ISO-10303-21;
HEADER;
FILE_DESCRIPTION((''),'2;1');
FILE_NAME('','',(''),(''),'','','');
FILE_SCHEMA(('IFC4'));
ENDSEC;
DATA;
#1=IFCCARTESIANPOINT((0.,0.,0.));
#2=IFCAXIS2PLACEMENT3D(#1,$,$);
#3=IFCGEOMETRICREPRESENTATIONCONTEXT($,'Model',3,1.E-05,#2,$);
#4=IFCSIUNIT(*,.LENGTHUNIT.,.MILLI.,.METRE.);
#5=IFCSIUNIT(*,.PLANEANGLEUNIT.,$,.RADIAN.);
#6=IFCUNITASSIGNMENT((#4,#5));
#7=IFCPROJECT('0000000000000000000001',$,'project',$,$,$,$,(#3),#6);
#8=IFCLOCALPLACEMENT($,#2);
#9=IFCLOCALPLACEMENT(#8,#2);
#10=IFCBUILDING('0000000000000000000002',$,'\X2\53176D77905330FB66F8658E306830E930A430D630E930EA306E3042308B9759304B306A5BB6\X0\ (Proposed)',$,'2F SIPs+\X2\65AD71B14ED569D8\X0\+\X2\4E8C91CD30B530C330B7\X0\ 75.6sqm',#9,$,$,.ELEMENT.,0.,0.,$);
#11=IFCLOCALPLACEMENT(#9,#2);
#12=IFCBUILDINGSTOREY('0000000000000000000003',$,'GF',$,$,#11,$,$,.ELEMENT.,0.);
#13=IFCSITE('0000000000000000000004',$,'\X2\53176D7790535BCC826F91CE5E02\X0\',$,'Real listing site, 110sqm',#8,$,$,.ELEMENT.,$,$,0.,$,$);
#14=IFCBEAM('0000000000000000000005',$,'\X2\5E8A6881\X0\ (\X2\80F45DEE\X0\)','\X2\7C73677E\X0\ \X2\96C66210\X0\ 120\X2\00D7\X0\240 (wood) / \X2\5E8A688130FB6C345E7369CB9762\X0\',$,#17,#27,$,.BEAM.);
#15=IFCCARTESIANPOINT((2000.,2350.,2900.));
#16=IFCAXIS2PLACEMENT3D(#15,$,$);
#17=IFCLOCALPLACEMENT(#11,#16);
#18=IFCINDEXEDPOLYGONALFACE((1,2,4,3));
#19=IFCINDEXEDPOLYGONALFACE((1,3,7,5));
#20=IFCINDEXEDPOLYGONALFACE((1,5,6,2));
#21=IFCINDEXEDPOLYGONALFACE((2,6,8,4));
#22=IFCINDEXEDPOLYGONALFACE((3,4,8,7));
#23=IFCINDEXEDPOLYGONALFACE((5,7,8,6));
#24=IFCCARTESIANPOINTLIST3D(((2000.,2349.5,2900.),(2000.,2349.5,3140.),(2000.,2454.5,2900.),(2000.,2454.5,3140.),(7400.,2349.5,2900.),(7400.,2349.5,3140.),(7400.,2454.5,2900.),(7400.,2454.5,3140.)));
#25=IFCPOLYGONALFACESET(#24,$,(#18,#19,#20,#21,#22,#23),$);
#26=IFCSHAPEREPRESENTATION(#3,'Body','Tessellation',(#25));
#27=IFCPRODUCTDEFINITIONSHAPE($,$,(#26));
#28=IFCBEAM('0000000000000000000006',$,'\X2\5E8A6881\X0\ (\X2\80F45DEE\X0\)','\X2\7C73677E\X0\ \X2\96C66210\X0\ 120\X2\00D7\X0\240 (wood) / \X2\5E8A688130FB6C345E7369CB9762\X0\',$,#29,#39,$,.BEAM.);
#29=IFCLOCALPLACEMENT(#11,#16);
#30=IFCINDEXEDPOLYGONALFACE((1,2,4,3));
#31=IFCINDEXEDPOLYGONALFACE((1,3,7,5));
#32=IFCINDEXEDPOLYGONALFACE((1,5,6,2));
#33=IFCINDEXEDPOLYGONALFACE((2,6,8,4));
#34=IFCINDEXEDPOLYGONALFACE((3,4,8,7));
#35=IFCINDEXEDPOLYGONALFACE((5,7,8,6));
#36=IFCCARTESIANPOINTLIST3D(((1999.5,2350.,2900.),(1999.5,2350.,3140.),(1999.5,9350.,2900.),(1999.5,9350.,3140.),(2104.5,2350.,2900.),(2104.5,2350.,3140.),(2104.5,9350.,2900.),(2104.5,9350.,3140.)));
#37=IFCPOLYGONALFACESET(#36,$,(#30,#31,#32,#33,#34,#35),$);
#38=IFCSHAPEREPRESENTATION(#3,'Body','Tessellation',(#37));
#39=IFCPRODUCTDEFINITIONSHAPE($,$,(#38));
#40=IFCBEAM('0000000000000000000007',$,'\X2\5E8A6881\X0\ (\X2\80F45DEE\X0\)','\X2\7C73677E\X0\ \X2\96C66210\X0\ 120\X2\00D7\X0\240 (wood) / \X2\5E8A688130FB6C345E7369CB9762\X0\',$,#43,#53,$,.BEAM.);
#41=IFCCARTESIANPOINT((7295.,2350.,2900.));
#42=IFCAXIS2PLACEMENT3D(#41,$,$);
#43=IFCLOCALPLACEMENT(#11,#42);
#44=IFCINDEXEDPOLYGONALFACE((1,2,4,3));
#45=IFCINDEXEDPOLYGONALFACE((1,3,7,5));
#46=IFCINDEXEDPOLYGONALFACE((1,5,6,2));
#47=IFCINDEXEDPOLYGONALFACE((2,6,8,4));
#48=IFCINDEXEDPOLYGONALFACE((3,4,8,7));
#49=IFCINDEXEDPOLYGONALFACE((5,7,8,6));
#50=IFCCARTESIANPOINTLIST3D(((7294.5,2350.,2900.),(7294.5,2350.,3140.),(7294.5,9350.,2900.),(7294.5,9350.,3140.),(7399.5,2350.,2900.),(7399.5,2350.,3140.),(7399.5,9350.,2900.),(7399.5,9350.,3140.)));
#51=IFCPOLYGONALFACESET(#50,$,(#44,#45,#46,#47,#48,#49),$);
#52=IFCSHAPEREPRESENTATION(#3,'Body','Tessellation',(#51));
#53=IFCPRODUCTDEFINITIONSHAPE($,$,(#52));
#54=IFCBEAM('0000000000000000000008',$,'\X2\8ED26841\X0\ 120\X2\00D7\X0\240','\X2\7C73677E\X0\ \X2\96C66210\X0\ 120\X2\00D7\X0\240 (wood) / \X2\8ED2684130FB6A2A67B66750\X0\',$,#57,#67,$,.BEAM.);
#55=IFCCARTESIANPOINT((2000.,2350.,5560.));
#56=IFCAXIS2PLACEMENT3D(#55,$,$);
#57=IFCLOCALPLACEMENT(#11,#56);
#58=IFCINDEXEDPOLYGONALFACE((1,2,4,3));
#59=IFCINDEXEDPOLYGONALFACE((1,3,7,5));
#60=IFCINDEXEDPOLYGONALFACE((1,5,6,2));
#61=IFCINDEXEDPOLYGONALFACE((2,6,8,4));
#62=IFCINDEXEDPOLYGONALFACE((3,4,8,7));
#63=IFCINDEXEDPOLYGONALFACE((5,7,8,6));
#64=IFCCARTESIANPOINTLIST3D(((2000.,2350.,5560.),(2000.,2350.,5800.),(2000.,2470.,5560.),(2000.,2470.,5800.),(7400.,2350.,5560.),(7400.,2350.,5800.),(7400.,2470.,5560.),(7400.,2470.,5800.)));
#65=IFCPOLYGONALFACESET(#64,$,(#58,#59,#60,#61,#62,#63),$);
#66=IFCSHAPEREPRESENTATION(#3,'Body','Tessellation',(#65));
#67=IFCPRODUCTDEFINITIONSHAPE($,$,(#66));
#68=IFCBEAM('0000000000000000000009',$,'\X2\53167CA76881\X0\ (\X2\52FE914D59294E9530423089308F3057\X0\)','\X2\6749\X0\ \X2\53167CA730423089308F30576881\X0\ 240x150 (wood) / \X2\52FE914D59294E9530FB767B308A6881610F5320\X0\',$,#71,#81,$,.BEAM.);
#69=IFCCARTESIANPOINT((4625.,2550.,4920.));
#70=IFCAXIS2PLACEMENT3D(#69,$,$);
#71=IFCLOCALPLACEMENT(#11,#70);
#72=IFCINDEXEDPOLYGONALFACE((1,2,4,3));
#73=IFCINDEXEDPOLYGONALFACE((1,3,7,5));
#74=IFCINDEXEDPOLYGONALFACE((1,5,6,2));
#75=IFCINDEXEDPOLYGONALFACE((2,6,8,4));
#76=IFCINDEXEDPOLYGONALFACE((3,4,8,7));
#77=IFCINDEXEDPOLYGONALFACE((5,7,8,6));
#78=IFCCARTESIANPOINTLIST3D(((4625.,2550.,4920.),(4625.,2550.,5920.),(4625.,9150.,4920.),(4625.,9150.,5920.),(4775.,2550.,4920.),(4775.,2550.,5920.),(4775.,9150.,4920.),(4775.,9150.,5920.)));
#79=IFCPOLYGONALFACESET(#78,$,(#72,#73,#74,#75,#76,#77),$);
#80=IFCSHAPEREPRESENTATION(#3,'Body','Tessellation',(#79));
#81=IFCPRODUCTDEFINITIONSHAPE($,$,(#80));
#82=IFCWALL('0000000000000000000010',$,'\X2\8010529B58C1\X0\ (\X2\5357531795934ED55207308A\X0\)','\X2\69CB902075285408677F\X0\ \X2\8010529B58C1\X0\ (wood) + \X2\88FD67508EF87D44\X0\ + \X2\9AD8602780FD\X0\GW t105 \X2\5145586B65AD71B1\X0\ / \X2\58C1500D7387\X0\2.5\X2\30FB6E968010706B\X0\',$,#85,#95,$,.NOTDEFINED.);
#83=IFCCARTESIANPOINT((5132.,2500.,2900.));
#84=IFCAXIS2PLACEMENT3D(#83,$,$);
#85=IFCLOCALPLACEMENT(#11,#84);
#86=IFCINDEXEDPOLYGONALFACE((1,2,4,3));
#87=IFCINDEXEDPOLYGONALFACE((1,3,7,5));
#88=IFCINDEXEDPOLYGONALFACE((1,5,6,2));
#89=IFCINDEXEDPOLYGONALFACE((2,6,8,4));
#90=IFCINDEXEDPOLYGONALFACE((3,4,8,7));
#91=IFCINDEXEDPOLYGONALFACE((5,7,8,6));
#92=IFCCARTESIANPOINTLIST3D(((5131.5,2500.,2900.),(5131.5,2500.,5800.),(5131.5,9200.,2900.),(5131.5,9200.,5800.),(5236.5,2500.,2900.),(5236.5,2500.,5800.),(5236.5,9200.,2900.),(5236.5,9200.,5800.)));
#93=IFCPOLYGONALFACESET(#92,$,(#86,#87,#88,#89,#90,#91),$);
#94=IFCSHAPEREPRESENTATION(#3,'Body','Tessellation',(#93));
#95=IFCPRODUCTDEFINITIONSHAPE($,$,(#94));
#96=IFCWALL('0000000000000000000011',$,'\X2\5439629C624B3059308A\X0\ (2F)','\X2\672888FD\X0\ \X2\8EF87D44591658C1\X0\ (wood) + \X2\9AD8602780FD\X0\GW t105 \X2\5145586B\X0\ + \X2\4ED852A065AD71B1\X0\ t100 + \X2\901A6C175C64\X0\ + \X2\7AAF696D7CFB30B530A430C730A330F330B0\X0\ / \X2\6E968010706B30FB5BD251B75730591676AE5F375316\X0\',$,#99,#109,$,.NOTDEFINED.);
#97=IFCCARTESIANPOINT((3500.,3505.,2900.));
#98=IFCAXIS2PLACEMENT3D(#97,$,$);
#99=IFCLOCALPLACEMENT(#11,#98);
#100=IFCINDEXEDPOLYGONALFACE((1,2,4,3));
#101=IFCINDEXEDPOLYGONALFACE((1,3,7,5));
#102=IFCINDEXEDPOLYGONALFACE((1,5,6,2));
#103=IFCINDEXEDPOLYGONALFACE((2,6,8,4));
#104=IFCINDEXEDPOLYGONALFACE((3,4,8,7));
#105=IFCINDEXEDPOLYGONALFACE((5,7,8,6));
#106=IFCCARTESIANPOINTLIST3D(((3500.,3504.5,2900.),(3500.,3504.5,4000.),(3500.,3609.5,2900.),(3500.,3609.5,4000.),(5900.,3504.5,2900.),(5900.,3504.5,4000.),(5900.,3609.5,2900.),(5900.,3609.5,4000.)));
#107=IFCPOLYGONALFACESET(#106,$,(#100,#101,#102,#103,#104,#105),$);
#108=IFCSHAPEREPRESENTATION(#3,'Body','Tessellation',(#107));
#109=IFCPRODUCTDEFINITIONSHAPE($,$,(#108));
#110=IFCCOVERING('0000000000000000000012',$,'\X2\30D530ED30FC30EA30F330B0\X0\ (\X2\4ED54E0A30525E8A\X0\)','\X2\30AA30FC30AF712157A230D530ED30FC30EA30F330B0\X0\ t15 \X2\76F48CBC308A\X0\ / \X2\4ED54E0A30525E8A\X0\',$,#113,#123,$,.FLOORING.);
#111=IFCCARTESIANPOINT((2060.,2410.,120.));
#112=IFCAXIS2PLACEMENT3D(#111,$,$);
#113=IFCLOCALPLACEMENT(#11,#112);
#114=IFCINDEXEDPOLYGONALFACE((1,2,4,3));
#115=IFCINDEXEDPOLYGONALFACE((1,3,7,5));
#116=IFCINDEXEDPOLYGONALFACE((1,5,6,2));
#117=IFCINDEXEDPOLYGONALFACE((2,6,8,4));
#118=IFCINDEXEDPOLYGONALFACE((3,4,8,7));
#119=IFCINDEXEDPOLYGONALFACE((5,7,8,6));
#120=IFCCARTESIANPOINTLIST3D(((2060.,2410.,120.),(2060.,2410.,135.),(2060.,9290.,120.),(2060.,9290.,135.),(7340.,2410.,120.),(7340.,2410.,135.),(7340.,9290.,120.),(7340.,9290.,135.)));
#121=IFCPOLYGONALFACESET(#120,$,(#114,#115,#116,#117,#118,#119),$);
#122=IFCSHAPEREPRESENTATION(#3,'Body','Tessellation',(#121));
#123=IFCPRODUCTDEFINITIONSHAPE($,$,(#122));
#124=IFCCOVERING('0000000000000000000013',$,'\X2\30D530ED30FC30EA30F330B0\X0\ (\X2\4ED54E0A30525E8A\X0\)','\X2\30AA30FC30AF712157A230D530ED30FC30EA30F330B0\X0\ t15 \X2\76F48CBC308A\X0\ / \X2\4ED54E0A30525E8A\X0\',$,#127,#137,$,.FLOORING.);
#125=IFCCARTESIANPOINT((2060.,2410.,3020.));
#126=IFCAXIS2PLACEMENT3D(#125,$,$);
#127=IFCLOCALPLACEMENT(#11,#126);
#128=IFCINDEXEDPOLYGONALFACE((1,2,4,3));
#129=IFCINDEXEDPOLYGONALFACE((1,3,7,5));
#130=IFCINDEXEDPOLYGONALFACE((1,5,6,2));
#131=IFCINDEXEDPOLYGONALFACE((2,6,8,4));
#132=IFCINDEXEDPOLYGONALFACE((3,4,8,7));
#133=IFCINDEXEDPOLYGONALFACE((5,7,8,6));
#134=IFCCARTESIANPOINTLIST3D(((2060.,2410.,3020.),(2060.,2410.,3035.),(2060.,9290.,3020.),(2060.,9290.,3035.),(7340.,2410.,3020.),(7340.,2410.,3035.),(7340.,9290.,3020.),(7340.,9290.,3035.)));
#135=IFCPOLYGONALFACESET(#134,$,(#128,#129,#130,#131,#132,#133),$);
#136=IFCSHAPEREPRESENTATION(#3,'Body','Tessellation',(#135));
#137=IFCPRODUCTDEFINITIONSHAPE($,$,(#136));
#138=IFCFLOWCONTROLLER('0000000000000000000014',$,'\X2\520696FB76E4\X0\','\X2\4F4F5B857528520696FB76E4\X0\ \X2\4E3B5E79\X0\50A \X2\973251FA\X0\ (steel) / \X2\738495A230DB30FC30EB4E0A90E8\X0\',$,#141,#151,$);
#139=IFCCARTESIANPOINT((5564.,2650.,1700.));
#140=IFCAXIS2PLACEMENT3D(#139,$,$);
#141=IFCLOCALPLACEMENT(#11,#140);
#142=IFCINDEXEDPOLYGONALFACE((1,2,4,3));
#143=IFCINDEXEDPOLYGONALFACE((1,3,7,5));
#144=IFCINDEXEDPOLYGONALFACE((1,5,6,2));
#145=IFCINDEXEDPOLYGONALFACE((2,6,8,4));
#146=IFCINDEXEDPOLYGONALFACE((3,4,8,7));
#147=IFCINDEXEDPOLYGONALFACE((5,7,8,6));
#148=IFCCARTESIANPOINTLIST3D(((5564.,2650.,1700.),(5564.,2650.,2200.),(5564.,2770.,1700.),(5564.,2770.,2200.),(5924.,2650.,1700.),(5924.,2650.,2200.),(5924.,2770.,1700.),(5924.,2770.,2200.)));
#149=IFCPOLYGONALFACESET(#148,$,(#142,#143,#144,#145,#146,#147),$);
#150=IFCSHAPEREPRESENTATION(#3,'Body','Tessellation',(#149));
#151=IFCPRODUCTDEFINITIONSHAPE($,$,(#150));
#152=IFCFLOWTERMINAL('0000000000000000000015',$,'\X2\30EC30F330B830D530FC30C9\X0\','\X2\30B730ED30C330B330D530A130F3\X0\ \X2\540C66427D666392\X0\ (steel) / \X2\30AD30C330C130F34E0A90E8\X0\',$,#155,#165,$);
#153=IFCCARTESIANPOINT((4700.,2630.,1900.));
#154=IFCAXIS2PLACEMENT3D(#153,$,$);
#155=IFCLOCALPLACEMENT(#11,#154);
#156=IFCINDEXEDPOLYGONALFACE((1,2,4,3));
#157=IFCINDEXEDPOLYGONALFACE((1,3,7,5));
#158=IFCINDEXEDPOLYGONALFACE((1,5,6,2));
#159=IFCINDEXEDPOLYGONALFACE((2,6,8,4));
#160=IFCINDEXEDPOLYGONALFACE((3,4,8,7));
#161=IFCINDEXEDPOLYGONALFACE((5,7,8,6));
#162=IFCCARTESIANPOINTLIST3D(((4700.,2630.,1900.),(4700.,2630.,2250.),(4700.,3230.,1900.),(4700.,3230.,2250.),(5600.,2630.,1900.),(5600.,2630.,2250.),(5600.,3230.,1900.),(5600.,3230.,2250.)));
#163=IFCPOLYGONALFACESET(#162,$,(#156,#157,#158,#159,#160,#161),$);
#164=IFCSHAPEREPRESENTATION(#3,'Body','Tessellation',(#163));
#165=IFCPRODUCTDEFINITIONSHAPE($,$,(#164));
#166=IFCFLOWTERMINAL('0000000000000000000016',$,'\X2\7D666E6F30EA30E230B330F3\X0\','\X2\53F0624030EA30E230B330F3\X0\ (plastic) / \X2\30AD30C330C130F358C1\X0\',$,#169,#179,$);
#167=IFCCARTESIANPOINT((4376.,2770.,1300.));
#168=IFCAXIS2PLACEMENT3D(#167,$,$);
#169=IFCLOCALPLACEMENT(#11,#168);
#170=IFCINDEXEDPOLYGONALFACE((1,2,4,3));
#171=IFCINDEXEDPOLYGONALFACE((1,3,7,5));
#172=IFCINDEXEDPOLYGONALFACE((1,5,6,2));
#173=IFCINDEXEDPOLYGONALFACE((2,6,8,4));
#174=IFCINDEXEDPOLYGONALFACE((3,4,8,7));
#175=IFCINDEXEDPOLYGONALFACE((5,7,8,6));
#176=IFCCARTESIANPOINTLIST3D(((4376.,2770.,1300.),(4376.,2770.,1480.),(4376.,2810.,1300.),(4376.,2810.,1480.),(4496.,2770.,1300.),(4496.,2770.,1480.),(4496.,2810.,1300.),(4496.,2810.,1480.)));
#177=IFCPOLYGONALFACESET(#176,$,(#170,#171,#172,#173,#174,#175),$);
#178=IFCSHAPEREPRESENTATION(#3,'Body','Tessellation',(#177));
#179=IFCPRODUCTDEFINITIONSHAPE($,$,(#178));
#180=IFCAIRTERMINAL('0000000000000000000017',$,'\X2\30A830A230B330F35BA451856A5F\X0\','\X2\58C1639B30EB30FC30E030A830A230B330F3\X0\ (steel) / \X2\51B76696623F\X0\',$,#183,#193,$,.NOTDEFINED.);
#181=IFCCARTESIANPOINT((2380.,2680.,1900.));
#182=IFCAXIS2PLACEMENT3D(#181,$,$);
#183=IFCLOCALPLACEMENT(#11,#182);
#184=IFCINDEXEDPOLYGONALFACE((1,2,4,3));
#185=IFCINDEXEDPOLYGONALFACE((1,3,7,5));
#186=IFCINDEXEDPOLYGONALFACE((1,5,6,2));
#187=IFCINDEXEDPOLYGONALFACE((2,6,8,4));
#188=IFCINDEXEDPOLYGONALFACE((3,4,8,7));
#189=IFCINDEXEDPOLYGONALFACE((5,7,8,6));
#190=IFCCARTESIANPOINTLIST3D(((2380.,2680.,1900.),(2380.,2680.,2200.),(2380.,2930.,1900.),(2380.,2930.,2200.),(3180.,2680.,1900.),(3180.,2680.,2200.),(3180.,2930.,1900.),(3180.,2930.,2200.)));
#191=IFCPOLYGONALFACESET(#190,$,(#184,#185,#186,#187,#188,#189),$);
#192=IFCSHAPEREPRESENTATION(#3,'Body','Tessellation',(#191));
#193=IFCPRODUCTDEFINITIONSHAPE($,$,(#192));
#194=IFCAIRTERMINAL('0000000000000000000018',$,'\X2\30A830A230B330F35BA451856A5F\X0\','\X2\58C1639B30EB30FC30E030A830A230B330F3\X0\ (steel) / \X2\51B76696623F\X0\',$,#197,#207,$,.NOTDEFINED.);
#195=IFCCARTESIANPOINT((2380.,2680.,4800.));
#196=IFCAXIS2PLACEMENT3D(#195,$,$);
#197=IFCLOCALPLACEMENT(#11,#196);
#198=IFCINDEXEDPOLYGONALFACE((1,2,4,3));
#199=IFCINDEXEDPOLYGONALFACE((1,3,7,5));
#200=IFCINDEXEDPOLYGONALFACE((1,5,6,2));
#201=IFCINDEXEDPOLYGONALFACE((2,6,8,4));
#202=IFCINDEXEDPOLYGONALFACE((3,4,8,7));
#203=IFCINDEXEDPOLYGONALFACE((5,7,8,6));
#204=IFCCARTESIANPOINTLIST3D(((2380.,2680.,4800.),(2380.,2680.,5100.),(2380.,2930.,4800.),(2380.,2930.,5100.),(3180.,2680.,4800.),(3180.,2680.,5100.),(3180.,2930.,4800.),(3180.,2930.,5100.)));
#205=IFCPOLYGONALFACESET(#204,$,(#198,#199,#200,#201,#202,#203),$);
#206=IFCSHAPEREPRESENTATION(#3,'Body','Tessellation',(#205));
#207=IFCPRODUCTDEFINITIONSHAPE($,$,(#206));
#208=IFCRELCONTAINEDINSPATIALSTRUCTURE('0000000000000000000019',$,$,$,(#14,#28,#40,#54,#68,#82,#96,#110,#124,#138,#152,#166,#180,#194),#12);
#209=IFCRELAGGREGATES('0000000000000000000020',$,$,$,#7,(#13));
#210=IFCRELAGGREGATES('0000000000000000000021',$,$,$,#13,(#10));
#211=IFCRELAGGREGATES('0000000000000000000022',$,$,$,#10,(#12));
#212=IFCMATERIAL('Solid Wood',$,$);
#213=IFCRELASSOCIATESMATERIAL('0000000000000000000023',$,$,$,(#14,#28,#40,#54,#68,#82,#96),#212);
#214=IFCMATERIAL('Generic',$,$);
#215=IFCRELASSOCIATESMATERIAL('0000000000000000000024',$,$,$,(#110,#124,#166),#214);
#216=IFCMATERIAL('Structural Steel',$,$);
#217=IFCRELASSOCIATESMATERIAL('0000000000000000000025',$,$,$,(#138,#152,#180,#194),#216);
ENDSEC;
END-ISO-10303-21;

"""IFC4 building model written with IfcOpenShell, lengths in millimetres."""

from ifc_helpers import new_model, si_unit, frame, frame_2d, origin, place, context, project, spatial, rectangle, extrude, material, element, save


model = new_model("IFC4")

# Units and contexts
model_context = context("Model", 3, precision=1e-05, world=origin())
ifc_project = project(units=[si_unit("LENGTHUNIT", "METRE", prefix="MILLI"), si_unit("PLANEANGLEUNIT", "RADIAN")], contexts=[model_context])

# Site, building, storey
site_placement = place(None, origin())
site = spatial("IfcSite", under=ifc_project, at=site_placement, Name="北海道富良野市", ObjectType="Real listing site, 110sqm", CompositionType="ELEMENT", RefElevation=0.0)
building_placement = place(site_placement, origin())
building = spatial("IfcBuilding", under=site, at=building_placement, Name="北海道・書斎とライブラリのある静かな家 (Proposed)", ObjectType="2F SIPs+断熱仕様+二重サッシ 75.6sqm", CompositionType="ELEMENT", ElevationOfRefHeight=0.0, ElevationOfTerrain=0.0)
storey_placement = place(building_placement, origin())
storey = spatial("IfcBuildingStorey", under=building, at=storey_placement, Name="GF", CompositionType="ELEMENT", Elevation=0.0)

# Beams
ifc_material_1 = material(Name="Solid Wood")
beam_1_placement = place(storey_placement, frame((2000.0, 2350.0, 2900.0)))
element("IfcBeam", 1, at=beam_1_placement, inside=storey, material=ifc_material_1, Name="床梁 (胴差)", Description="米松 集成 120×240 (wood) / 床梁・水平構面", PredefinedType="BEAM", context=model_context, shape_type="SweptSolid", body=[
    extrude(rectangle(XDim=5400.0, YDim=105.0, at=frame_2d((2700.0, 52.0))), frame((2000.0, 2350.0, 2900.0)), (0.0, 0.0, 1.0), 240.0),
])
beam_2_placement = place(storey_placement, frame((2000.0, 2350.0, 2900.0)))
element("IfcBeam", 2, at=beam_2_placement, inside=storey, material=ifc_material_1, Name="床梁 (胴差)", Description="米松 集成 120×240 (wood) / 床梁・水平構面", PredefinedType="BEAM", context=model_context, shape_type="SweptSolid", body=[
    extrude(rectangle(XDim=105.0, YDim=7000.0, at=frame_2d((52.0, 3500.0))), frame((2000.0, 2350.0, 2900.0)), (0.0, 0.0, 1.0), 240.0),
])
beam_3_placement = place(storey_placement, frame((7295.0, 2350.0, 2900.0)))
element("IfcBeam", 3, at=beam_3_placement, inside=storey, material=ifc_material_1, Name="床梁 (胴差)", Description="米松 集成 120×240 (wood) / 床梁・水平構面", PredefinedType="BEAM", context=model_context, shape_type="SweptSolid", body=[
    extrude(rectangle(XDim=105.0, YDim=7000.0, at=frame_2d((52.0, 3500.0))), frame((7295.0, 2350.0, 2900.0)), (0.0, 0.0, 1.0), 240.0),
])
beam_4_placement = place(storey_placement, frame((2000.0, 2350.0, 5560.0)))
element("IfcBeam", 4, at=beam_4_placement, inside=storey, material=ifc_material_1, Name="軒桁 120×240", Description="米松 集成 120×240 (wood) / 軒桁・横架材", PredefinedType="BEAM", context=model_context, shape_type="SweptSolid", body=[
    extrude(rectangle(XDim=5400.0, YDim=120.0, at=frame_2d((2700.0, 60.0))), frame((2000.0, 2350.0, 5560.0)), (0.0, 0.0, 1.0), 240.0),
])
beam_5_placement = place(storey_placement, frame((4625.0, 2550.0, 4920.0)))
element("IfcBeam", 5, at=beam_5_placement, inside=storey, material=ifc_material_1, Name="化粧梁 (勾配天井あらわし)", Description="杉 化粧あらわし梁 240x150 (wood) / 勾配天井・登り梁意匠", PredefinedType="BEAM", context=model_context, shape_type="SweptSolid", body=[
    extrude(rectangle(XDim=150.0, YDim=6600.0, at=frame_2d((75.0, 3300.0))), frame((4625.0, 2550.0, 4920.0)), (0.0, 0.0, 1.0), 1000.0),
])

# Walls
wall_1_placement = place(storey_placement, frame((5132.0, 2500.0, 2900.0)))
element("IfcWall", 6, at=wall_1_placement, inside=storey, material=ifc_material_1, Name="耐力壁 (南北間仕切り)", Description="構造用合板 耐力壁 (wood) + 製材軸組 + 高性能GW t105 充填断熱 / 壁倍率2.5・準耐火", PredefinedType="NOTDEFINED", context=model_context, shape_type="SweptSolid", body=[
    extrude(rectangle(XDim=105.0, YDim=6700.0, at=frame_2d((52.0, 3350.0))), frame((5132.0, 2500.0, 2900.0)), (0.0, 0.0, 1.0), 2900.0),
])
wall_2_placement = place(storey_placement, frame((3500.0, 3505.0, 2900.0)))
element("IfcWall", 7, at=wall_2_placement, inside=storey, material=ifc_material_1, Name="吹抜手すり (2F)", Description="木製 軸組外壁 (wood) + 高性能GW t105 充填 + 付加断熱 t100 + 通気層 + 窯業系サイディング / 準耐火・寒冷地外皮強化", PredefinedType="NOTDEFINED", context=model_context, shape_type="SweptSolid", body=[
    extrude(rectangle(XDim=2400.0, YDim=105.0, at=frame_2d((1200.0, 52.0))), frame((3500.0, 3505.0, 2900.0)), (0.0, 0.0, 1.0), 1100.0),
])

# Coverings
ifc_material_2 = material(Name="Generic")
covering_1_placement = place(storey_placement, frame((2060.0, 2410.0, 120.0)))
element("IfcCovering", 8, at=covering_1_placement, inside=storey, material=ifc_material_2, Name="フローリング (仕上げ床)", Description="オーク無垢フローリング t15 直貼り / 仕上げ床", PredefinedType="FLOORING", context=model_context, shape_type="SweptSolid", body=[
    extrude(rectangle(XDim=5280.0, YDim=6880.0, at=frame_2d((2640.0, 3440.0))), frame((2060.0, 2410.0, 120.0)), (0.0, 0.0, 1.0), 15.0),
])
covering_2_placement = place(storey_placement, frame((2060.0, 2410.0, 3020.0)))
element("IfcCovering", 9, at=covering_2_placement, inside=storey, material=ifc_material_2, Name="フローリング (仕上げ床)", Description="オーク無垢フローリング t15 直貼り / 仕上げ床", PredefinedType="FLOORING", context=model_context, shape_type="SweptSolid", body=[
    extrude(rectangle(XDim=5280.0, YDim=6880.0, at=frame_2d((2640.0, 3440.0))), frame((2060.0, 2410.0, 3020.0)), (0.0, 0.0, 1.0), 15.0),
])

# Flow controller
ifc_material_3 = material(Name="Structural Steel")
flow_controller_placement = place(storey_placement, frame((5564.0, 2650.0, 1700.0)))
element("IfcFlowController", 10, at=flow_controller_placement, inside=storey, material=ifc_material_3, Name="分電盤", Description="住宅用分電盤 主幹50A 露出 (steel) / 玄関ホール上部", context=model_context, shape_type="SweptSolid", body=[
    extrude(rectangle(XDim=360.0, YDim=120.0, at=frame_2d((180.0, 60.0))), frame((5564.0, 2650.0, 1700.0)), (0.0, 0.0, 1.0), 500.0),
])

# Flow terminals
flow_terminal_1_placement = place(storey_placement, frame((4700.0, 2630.0, 1900.0)))
element("IfcFlowTerminal", 11, at=flow_terminal_1_placement, inside=storey, material=ifc_material_3, Name="レンジフード", Description="シロッコファン 同時給排 (steel) / キッチン上部", context=model_context, shape_type="SweptSolid", body=[
    extrude(rectangle(XDim=900.0, YDim=600.0, at=frame_2d((450.0, 300.0))), frame((4700.0, 2630.0, 1900.0)), (0.0, 0.0, 1.0), 350.0),
])
flow_terminal_2_placement = place(storey_placement, frame((4376.0, 2770.0, 1300.0)))
element("IfcFlowTerminal", 12, at=flow_terminal_2_placement, inside=storey, material=ifc_material_2, Name="給湯リモコン", Description="台所リモコン (plastic) / キッチン壁", context=model_context, shape_type="SweptSolid", body=[
    extrude(rectangle(XDim=120.0, YDim=40.0, at=frame_2d((60.0, 20.0))), frame((4376.0, 2770.0, 1300.0)), (0.0, 0.0, 1.0), 180.0),
])

# Air terminals
air_terminal_1_placement = place(storey_placement, frame((2380.0, 2680.0, 1900.0)))
element("IfcAirTerminal", 13, at=air_terminal_1_placement, inside=storey, material=ifc_material_3, Name="エアコン室内機", Description="壁掛ルームエアコン (steel) / 冷暖房", PredefinedType="NOTDEFINED", context=model_context, shape_type="SweptSolid", body=[
    extrude(rectangle(XDim=800.0, YDim=250.0, at=frame_2d((400.0, 125.0))), frame((2380.0, 2680.0, 1900.0)), (0.0, 0.0, 1.0), 300.0),
])
air_terminal_2_placement = place(storey_placement, frame((2380.0, 2680.0, 4800.0)))
element("IfcAirTerminal", 14, at=air_terminal_2_placement, inside=storey, material=ifc_material_3, Name="エアコン室内機", Description="壁掛ルームエアコン (steel) / 冷暖房", PredefinedType="NOTDEFINED", context=model_context, shape_type="SweptSolid", body=[
    extrude(rectangle(XDim=800.0, YDim=250.0, at=frame_2d((400.0, 125.0))), frame((2380.0, 2680.0, 4800.0)), (0.0, 0.0, 1.0), 300.0),
])

save(model, "model.ifc")
